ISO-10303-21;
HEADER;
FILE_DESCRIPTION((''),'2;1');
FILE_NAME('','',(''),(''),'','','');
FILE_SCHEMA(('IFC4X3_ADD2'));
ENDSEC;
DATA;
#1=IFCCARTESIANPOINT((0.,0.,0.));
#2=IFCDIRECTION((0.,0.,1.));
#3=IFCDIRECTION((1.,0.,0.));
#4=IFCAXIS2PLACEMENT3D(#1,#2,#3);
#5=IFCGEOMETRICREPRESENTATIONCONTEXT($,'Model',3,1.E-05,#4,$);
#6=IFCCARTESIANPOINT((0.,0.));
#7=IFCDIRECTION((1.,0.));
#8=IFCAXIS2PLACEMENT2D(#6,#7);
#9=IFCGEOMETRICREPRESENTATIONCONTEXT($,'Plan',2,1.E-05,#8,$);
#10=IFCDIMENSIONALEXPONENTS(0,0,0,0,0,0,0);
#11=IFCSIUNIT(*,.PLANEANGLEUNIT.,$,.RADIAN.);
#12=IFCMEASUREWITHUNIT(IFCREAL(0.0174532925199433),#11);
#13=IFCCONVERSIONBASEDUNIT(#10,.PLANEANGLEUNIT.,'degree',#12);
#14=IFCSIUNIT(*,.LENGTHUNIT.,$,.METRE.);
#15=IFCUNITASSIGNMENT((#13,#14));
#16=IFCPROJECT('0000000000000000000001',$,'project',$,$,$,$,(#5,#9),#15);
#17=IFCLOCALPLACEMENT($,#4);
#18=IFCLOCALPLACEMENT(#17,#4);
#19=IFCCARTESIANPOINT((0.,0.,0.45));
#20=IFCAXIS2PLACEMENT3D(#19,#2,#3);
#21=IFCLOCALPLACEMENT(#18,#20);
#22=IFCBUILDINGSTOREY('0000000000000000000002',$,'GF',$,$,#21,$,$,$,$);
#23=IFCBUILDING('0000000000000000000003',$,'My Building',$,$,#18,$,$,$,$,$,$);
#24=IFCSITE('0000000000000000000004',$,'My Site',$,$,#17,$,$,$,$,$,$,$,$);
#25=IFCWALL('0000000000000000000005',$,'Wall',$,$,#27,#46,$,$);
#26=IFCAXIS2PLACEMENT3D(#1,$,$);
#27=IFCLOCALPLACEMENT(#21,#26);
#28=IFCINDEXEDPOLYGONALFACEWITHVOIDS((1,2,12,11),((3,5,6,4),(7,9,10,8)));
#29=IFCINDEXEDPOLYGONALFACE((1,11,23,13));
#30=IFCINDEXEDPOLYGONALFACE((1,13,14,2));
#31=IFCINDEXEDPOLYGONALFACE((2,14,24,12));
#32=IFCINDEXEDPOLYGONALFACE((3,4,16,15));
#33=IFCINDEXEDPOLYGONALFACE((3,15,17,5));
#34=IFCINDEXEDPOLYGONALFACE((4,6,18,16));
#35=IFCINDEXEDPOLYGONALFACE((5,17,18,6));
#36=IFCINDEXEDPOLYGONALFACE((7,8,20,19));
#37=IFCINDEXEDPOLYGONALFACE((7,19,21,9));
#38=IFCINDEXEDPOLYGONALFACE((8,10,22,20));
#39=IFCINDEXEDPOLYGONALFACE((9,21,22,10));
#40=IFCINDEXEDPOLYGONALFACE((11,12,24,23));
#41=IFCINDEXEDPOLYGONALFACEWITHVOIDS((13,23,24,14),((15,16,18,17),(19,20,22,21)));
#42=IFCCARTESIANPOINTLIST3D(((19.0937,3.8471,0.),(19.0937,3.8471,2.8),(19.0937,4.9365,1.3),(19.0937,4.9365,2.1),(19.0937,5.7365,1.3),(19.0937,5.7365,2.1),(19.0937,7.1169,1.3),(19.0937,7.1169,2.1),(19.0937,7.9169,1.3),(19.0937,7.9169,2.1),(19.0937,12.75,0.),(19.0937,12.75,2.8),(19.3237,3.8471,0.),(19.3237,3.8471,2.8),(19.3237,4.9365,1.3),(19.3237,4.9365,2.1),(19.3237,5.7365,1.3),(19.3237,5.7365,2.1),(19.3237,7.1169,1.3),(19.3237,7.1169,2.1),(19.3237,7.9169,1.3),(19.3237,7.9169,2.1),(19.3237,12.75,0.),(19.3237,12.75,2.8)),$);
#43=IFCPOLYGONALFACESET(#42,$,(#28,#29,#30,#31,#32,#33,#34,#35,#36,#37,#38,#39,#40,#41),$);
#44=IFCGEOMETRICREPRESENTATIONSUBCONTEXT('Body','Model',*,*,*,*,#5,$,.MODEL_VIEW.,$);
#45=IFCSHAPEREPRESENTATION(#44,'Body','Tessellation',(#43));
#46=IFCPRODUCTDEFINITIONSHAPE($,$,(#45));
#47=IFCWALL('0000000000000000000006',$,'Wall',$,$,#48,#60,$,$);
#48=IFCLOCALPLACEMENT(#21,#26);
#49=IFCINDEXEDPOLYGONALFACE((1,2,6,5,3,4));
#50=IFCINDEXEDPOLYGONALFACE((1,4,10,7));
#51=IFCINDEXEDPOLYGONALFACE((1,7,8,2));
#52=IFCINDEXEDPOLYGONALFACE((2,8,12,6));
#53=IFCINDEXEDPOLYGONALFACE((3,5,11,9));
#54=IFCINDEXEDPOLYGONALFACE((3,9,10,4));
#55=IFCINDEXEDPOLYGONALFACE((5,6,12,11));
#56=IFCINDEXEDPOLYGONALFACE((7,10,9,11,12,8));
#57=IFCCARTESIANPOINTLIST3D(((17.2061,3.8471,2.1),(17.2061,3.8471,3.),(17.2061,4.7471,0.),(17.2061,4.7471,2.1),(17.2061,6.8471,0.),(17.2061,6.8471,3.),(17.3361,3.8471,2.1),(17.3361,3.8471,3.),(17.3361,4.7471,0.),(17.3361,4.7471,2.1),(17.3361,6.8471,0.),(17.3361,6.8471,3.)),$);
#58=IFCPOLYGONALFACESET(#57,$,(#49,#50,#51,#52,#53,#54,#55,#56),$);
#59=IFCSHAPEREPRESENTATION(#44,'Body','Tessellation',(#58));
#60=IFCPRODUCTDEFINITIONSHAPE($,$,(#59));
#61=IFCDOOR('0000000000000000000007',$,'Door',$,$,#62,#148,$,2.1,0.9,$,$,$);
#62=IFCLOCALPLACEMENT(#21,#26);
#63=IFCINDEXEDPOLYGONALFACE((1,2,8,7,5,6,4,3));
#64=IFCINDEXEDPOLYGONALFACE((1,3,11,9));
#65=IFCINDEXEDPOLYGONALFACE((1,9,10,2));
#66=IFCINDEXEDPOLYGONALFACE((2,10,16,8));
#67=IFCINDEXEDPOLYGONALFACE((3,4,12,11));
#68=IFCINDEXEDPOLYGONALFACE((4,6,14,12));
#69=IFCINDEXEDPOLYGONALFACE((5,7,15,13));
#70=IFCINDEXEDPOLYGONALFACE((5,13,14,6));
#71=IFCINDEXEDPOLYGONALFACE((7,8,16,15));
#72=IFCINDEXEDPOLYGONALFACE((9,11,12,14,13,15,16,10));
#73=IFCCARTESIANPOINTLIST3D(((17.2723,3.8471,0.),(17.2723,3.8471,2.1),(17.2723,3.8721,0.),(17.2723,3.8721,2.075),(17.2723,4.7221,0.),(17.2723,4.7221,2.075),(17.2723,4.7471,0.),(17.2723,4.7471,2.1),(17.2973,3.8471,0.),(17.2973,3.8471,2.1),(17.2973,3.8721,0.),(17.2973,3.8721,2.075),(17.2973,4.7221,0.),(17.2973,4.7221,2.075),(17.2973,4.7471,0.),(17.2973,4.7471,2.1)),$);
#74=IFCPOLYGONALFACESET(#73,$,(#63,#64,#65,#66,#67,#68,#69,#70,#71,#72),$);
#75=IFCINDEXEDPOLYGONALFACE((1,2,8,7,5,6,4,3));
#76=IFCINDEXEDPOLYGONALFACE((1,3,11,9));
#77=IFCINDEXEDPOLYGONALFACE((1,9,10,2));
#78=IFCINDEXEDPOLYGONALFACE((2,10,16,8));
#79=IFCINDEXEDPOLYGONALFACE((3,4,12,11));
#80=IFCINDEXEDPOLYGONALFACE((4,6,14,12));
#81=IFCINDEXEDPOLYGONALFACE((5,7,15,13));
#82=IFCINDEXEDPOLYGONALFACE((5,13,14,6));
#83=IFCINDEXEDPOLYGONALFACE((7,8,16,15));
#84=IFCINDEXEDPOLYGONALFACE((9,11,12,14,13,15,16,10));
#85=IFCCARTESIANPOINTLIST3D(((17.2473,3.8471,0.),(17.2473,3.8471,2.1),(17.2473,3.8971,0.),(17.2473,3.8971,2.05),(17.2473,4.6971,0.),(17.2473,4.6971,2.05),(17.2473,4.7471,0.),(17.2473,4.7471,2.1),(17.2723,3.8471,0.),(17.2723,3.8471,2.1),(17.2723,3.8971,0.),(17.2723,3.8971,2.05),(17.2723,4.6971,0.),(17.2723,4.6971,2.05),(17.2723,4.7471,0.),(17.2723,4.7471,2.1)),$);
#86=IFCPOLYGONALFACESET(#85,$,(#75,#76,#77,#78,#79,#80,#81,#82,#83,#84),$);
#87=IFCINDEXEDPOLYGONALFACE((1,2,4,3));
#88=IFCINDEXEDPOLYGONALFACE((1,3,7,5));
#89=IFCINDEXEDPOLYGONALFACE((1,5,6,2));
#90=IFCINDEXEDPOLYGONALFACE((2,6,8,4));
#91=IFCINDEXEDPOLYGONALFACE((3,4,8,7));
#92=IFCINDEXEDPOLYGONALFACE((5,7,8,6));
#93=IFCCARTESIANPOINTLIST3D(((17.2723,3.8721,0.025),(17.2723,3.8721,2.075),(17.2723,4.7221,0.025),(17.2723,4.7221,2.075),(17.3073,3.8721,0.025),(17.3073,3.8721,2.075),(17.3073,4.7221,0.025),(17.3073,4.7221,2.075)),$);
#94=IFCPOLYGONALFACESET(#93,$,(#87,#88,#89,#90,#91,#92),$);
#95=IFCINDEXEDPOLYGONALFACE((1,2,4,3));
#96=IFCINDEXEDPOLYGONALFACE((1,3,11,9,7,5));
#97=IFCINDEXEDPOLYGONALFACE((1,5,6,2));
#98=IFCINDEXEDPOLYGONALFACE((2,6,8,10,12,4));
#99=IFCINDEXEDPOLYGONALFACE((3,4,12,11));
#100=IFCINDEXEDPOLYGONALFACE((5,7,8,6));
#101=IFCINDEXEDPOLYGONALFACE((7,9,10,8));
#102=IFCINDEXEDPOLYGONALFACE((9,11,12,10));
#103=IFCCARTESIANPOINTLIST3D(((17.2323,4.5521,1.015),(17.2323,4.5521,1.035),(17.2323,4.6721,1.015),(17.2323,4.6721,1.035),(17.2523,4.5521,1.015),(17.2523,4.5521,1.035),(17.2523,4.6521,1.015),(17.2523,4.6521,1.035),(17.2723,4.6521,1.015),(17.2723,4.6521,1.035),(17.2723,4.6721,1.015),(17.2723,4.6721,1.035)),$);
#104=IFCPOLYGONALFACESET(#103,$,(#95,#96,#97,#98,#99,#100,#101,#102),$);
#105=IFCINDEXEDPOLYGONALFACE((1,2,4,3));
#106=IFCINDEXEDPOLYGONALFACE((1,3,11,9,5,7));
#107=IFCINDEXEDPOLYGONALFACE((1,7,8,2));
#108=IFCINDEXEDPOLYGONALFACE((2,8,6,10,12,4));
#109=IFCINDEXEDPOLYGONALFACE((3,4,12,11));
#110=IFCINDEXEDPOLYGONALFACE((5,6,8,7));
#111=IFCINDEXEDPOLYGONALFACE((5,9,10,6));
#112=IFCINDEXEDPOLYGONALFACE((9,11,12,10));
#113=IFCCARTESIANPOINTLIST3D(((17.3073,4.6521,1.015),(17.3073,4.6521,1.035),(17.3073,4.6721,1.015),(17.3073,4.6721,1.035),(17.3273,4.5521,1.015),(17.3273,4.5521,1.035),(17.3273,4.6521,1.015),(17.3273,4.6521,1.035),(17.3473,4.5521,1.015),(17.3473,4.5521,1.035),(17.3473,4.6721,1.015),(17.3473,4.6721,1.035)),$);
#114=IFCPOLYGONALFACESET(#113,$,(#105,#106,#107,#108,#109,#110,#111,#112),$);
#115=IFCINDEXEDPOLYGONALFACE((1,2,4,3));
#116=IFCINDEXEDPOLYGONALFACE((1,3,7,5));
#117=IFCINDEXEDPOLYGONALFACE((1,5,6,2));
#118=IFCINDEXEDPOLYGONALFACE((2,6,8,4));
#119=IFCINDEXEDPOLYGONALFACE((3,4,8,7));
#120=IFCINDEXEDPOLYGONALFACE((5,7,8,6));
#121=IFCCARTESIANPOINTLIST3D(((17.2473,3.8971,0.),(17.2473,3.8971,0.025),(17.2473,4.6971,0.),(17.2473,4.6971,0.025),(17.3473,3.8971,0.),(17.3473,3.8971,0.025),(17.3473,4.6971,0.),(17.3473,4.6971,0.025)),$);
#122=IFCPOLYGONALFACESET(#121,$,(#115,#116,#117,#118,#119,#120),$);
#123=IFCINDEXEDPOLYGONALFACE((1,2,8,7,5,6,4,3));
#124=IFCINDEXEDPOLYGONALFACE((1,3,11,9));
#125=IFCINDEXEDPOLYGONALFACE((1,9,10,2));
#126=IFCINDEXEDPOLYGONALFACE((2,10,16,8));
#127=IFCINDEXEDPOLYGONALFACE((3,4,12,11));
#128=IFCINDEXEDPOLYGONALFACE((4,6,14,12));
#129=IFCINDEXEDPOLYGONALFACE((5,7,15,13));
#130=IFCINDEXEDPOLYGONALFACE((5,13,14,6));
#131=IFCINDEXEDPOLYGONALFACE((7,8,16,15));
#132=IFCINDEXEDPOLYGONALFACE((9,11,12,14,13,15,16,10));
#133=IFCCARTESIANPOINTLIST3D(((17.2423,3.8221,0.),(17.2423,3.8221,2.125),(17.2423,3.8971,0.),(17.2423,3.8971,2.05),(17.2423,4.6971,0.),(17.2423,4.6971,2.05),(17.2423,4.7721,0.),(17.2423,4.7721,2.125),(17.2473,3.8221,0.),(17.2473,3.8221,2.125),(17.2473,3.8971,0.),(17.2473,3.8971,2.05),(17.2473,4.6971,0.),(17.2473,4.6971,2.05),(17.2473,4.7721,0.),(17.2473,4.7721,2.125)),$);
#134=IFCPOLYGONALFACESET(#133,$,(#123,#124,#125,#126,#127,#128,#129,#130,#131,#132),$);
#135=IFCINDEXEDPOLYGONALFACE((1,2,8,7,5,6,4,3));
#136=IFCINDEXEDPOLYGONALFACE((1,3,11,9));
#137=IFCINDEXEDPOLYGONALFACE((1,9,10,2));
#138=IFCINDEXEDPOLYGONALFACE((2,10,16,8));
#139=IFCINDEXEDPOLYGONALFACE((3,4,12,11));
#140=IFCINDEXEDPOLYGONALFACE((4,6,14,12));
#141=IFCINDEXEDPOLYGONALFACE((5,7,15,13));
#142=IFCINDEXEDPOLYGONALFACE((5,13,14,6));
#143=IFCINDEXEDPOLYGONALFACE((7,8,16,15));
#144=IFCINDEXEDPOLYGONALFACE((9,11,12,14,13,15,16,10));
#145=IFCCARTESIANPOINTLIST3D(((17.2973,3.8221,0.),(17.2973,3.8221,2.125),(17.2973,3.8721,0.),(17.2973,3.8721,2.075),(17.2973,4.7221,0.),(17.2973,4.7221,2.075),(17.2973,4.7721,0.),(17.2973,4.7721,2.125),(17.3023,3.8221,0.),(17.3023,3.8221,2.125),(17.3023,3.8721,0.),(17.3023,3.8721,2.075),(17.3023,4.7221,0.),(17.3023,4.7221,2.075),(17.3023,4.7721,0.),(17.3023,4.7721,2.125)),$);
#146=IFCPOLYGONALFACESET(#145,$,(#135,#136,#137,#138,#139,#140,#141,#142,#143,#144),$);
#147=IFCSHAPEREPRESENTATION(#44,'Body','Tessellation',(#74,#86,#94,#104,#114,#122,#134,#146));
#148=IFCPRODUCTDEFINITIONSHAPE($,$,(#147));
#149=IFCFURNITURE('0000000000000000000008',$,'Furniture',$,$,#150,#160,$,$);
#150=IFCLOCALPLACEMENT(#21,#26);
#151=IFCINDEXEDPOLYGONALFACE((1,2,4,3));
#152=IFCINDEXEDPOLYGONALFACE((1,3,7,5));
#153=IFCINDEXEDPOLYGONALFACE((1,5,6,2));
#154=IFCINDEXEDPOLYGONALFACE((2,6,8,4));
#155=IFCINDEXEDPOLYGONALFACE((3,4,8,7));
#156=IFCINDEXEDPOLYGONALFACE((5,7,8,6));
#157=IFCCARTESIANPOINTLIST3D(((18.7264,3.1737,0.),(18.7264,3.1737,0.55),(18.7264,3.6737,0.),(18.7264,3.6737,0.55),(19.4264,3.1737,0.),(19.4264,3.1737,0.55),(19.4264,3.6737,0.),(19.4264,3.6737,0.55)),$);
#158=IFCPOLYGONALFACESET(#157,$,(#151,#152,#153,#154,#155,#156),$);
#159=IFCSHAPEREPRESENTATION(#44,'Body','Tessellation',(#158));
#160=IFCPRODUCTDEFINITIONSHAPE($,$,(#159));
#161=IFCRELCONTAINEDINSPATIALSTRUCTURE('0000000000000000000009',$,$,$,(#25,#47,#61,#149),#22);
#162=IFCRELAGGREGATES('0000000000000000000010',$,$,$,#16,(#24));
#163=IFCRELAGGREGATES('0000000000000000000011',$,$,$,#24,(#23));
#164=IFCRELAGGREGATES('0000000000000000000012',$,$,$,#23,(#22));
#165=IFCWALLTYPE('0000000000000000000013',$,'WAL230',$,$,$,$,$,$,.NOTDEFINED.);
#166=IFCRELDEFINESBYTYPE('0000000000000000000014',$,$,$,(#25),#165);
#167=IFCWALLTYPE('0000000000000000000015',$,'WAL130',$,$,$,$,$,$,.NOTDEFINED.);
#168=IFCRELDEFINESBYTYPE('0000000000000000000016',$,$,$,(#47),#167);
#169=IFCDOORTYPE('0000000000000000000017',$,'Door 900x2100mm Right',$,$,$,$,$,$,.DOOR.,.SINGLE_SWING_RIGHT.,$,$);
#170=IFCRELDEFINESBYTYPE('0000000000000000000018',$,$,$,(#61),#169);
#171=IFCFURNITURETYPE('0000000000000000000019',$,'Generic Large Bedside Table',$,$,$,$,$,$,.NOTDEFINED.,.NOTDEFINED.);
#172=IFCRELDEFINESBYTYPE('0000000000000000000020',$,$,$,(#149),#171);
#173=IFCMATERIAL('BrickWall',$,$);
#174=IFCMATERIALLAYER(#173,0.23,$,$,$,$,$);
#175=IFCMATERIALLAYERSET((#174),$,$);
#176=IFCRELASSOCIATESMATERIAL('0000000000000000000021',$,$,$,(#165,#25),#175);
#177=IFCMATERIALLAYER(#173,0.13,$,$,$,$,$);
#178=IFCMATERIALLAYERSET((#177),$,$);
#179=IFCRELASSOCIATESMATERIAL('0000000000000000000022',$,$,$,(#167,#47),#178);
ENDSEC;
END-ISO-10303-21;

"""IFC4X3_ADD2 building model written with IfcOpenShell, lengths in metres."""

from ifc_helpers import new_model, entity, si_unit, converted_unit, frame, origin_with_axes, origin_2d_with_axis, place, context, subcontext, project, spatial, line, indexed_curve, outline, extrude, shape, source, transform, mapped, material, layer, layer_set, layer_usage, type_object, type_shapes, element, fill, save


model = new_model("IFC4X3_ADD2")

# Units and contexts
model_context = context("Model", 3, precision=1e-05, world=origin_with_axes())
plan_context = context("Plan", 2, precision=1e-05, world=origin_2d_with_axis())
body_context_1 = subcontext(model_context, "Body", "Model", "MODEL_VIEW")
body_context_2 = subcontext(plan_context, "Body", "Plan", "PLAN_VIEW")
ifc_project = project(units=[converted_unit("PLANEANGLEUNIT", "degree", entity("IfcReal", 0.0174532925199433), si_unit("PLANEANGLEUNIT", "RADIAN"), dimensions=[0, 0, 0, 0, 0, 0, 0]), si_unit("LENGTHUNIT", "METRE")], contexts=[model_context, plan_context])

# Site, building, storey
site_placement = place(None, origin_with_axes())
site = spatial("IfcSite", under=ifc_project, at=site_placement, Name="My Site")
building_placement = place(site_placement, origin_with_axes())
building = spatial("IfcBuilding", under=site, at=building_placement, Name="My Building")
storey_placement = place(building_placement, frame((0.0, 0.0, 0.45), z_axis=(0.0, 0.0, 1.0), x_axis=(1.0, 0.0, 0.0)))
storey = spatial("IfcBuildingStorey", under=building, at=storey_placement, Name="GF")

# Shared definitions
ifc_material = material(Name="BrickWall")
ifc_layer_1 = layer(ifc_material, 0.23)
ifc_layer_set_1 = layer_set([ifc_layer_1])
wall_type_1 = type_object("IfcWallType", Name="WAL230", PredefinedType="NOTDEFINED", material=ifc_layer_set_1)

# Wall, openings
ifc_layer_usage_1 = layer_usage(ifc_layer_set_1, "AXIS2", "POSITIVE", 0.0)
wall_1_placement = place(storey_placement, frame((19.3237, 3.8471, 0.0), z_axis=(0.0, 0.0, 1.0), x_axis=(0.0, 1.0, 0.0)))
wall_1 = element("IfcWall", 1, at=wall_1_placement, inside=storey, type_object=wall_type_1, material=ifc_layer_usage_1, Name="Wall", context=body_context_1, shape_type="SweptSolid", body=[
    extrude(outline(indexed_curve([(0.0, 0.0), (0.0, 0.23), (8.9029, 0.23), (8.9029, 0.0), (0.0, 0.0)], self_intersect=False)), origin_with_axes(), (0.0, 0.0, 1.0), 2.8),
])
shared_shape_1 = source(origin_with_axes(), body_context_1, "Body", "SweptSolid", [
    extrude(outline(indexed_curve([(0.0, 0.0), (0.8, 0.0), (0.8, 0.8), (0.0, 0.8)], segments=[line(1, 2, 3, 4, 1)])), frame((-0.4, -0.6, 0.0), z_axis=(0.0, -1.0, 0.0), x_axis=(1.0, 0.0, 0.0)), (0.0, 0.0, -1.0), 1.2),
])
opening_1_placement = place(wall_1_placement, frame((1.4894, 0.0, 1.3), z_axis=(0.0, 0.0, 1.0), x_axis=(1.0, 0.0, 0.0)))
element("IfcOpeningElement", 2, at=opening_1_placement, cuts=wall_1, PredefinedType="OPENING", context=body_context_1, shape_type="MappedRepresentation", body=[
    mapped(shared_shape_1, transform((0.0, 0.0, 0.0), x_axis=(1.0, 0.0, 0.0), y_axis=(0.0, 1.0, 0.0), z_axis=(0.0, 0.0, 1.0), scale=1.0)),
])
opening_2_placement = place(wall_1_placement, frame((3.6698, 0.0, 1.3), z_axis=(0.0, 0.0, 1.0), x_axis=(1.0, 0.0, 0.0)))
element("IfcOpeningElement", 3, at=opening_2_placement, cuts=wall_1, PredefinedType="OPENING", context=body_context_1, shape_type="MappedRepresentation", body=[
    mapped(shared_shape_1, transform((0.0, 0.0, 0.0), x_axis=(1.0, 0.0, 0.0), y_axis=(0.0, 1.0, 0.0), z_axis=(0.0, 0.0, 1.0), scale=1.0)),
])

# Wall, opening, door
ifc_layer_2 = layer(ifc_material, 0.13)
ifc_layer_set_2 = layer_set([ifc_layer_2])
ifc_layer_usage_2 = layer_usage(ifc_layer_set_2, "AXIS2", "POSITIVE", 0.0)
wall_type_2 = type_object("IfcWallType", Name="WAL130", PredefinedType="NOTDEFINED", material=ifc_layer_set_2)
wall_2_placement = place(storey_placement, frame((17.3361, 3.8471, 0.0), z_axis=(0.0, 0.0, 1.0), x_axis=(0.0, 1.0, 0.0)))
wall_2 = element("IfcWall", 4, at=wall_2_placement, inside=storey, type_object=wall_type_2, material=ifc_layer_usage_2, Name="Wall", context=body_context_1, shape_type="SweptSolid", body=[
    extrude(outline(indexed_curve([(0.0, 0.0), (0.0, 0.13), (3.0, 0.13), (3.0, 0.0), (0.0, 0.0)], self_intersect=False)), origin_with_axes(), (0.0, 0.0, 1.0), 3.0),
])
shared_shape_2 = source(origin_with_axes(), body_context_1, "Body", "SweptSolid", [
    extrude(outline(indexed_curve([(0.0, 0.0), (0.9, 0.0), (0.9, 2.1), (0.0, 2.1)], segments=[line(1, 2, 3, 4, 1)])), frame((0.0, -0.6, 0.0), z_axis=(0.0, -1.0, 0.0), x_axis=(1.0, 0.0, 0.0)), (0.0, 0.0, -1.0), 1.2),
])
opening_3_placement = place(wall_2_placement, frame((0.9, 0.0887, 0.0), z_axis=(0.0, 0.0, 1.0), x_axis=(-1.0, 0.0, 0.0)))
opening_3 = element("IfcOpeningElement", 5, at=opening_3_placement, cuts=wall_2, PredefinedType="OPENING", context=body_context_1, shape_type="MappedRepresentation", body=[
    mapped(shared_shape_2, transform((0.0, 0.0, 0.0), x_axis=(1.0, 0.0, 0.0), y_axis=(0.0, 1.0, 0.0), z_axis=(0.0, 0.0, 1.0), scale=1.0)),
])
door_type = type_object("IfcDoorType", Name="Door 900x2100mm Right", OperationType="SINGLE_SWING_RIGHT", PredefinedType="DOOR")
shared_shape_3 = source(origin_with_axes(), body_context_1, "Body", "SweptSolid", [
    extrude(outline(indexed_curve([(0.0, 0.0), (0.0, 2.1), (0.9, 2.1), (0.9, 0.0), (0.875, 0.0), (0.875, 2.075), (0.025, 2.075), (0.025, 0.0)], segments=[line(1, 2, 3, 4, 5, 6, 7, 8, 1)])), frame((0.0, 0.025, 0.0), z_axis=(0.0, -1.0, 0.0), x_axis=(1.0, 0.0, 0.0)), (0.0, 0.0, -1.0), 0.025),
    extrude(outline(indexed_curve([(0.0, 0.0), (0.0, 2.1), (0.9, 2.1), (0.9, 0.0), (0.85, 0.0), (0.85, 2.05), (0.05, 2.05), (0.05, 0.0)], segments=[line(1, 2, 3, 4, 5, 6, 7, 8, 1)])), frame((0.0, 0.0, 0.0), z_axis=(0.0, -1.0, 0.0), x_axis=(1.0, 0.0, 0.0)), (0.0, 0.0, -1.0), 0.025),
    extrude(outline(indexed_curve([(0.0, 0.0), (0.85, 0.0), (0.85, 0.035), (0.0, 0.035)], segments=[line(1, 2, 3, 4, 1)])), frame((0.025, 0.025, 0.025), z_axis=(0.0, 0.0, 1.0), x_axis=(1.0, 0.0, 0.0)), (0.0, 0.0, 1.0), 2.05),
    extrude(outline(indexed_curve([(0.0, 0.0), (0.0, -0.04), (0.12, -0.04), (0.12, -0.02), (0.02, -0.02), (0.02, 0.0)], segments=[line(1, 2, 3, 4, 5, 6, 1)])), frame((0.075, 0.025, 1.015), z_axis=(0.0, 0.0, 1.0), x_axis=(1.0, 0.0, 0.0)), (0.0, 0.0, 1.0), 0.02),
    extrude(outline(indexed_curve([(0.0, 0.0), (0.0, 0.04), (0.12, 0.04), (0.12, 0.02), (0.02, 0.02), (0.02, 0.0)], segments=[line(1, 2, 3, 4, 5, 6, 1)])), frame((0.075, 0.06, 1.015), z_axis=(0.0, 0.0, 1.0), x_axis=(1.0, 0.0, 0.0)), (0.0, 0.0, 1.0), 0.02),
    extrude(outline(indexed_curve([(0.0, 0.0), (0.8, 0.0), (0.8, 0.1), (0.0, 0.1)], segments=[line(1, 2, 3, 4, 1)])), frame((0.05, 0.0, 0.0), z_axis=(0.0, 0.0, 1.0), x_axis=(1.0, 0.0, 0.0)), (0.0, 0.0, 1.0), 0.025),
    extrude(outline(indexed_curve([(0.0, 0.0), (0.0, 2.125), (0.95, 2.125), (0.95, 0.0), (0.875, 0.0), (0.875, 2.05), (0.075, 2.05), (0.075, 0.0)], segments=[line(1, 2, 3, 4, 5, 6, 7, 8, 1)])), frame((-0.025, -0.005, 0.0), z_axis=(0.0, -1.0, 0.0), x_axis=(1.0, 0.0, 0.0)), (0.0, 0.0, -1.0), 0.005),
    extrude(outline(indexed_curve([(0.0, 0.0), (0.0, 2.125), (0.95, 2.125), (0.95, 0.0), (0.9, 0.0), (0.9, 2.075), (0.05, 2.075), (0.05, 0.0)], segments=[line(1, 2, 3, 4, 5, 6, 7, 8, 1)])), frame((-0.025, 0.05, 0.0), z_axis=(0.0, -1.0, 0.0), x_axis=(1.0, 0.0, 0.0)), (0.0, 0.0, -1.0), 0.005),
])
shared_shape_4 = source(origin_with_axes(), body_context_2, "Body", "Curve2D", [
    entity("IfcIndexedPolyCurve", entity("IfcCartesianPointList2D", [[0.0, 0.0], [0.0, 0.05], [0.025, 0.05], [0.025, 0.025], [0.05, 0.025], [0.05, 0.0]]), [entity("IfcLineIndex", [1, 2, 3, 4, 5, 6, 1])]),
    entity("IfcIndexedPolyCurve", entity("IfcCartesianPointList2D", [[0.9, 0.0], [0.9, 0.05], [0.875, 0.05], [0.875, 0.025], [0.85, 0.025], [0.85, 0.0]]), [entity("IfcLineIndex", [1, 2, 3, 4, 5, 6, 1])]),
    entity("IfcTrimmedCurve", entity("IfcEllipse", entity("IfcAxis2Placement2D", entity("IfcCartesianPoint", [0.84, 0.05]), entity("IfcDirection", [1.0, 0.0])), 0.815, 0.85), [entity("IfcCartesianPoint", [0.84, 0.9])], [entity("IfcCartesianPoint", [0.025, 0.05])], True, "CARTESIAN"),
    entity("IfcIndexedPolyCurve", entity("IfcCartesianPointList2D", [[0.875, 0.05], [0.84, 0.05], [0.84, 0.9], [0.875, 0.9]]), [entity("IfcLineIndex", [1, 2, 3, 4, 1])]),
])
type_shapes(door_type, [shared_shape_3, shared_shape_4])
door_placement = place(opening_3_placement, frame((0.0, 0.0, 0.0), z_axis=(0.0, 0.0, 1.0), x_axis=(1.0, 0.0, 0.0)))
door = element("IfcDoor", 6, at=door_placement, inside=storey, type_object=door_type, Name="Door", OverallHeight=2.1, OverallWidth=0.9, shapes=[
    shape(body_context_1, "Body", "MappedRepresentation", [mapped(shared_shape_3, transform((0.0, 0.0, 0.0), x_axis=(1.0, 0.0, 0.0), y_axis=(0.0, 1.0, 0.0), z_axis=(0.0, 0.0, 1.0), scale=1.0))]),
    shape(body_context_2, "Body", "MappedRepresentation", [mapped(shared_shape_4, transform((0.0, 0.0, 0.0), x_axis=(1.0, 0.0, 0.0), y_axis=(0.0, 1.0, 0.0), z_axis=(0.0, 0.0, 1.0), scale=1.0))]),
])
fill(opening_3, door)

# Furniture
furniture_type_1 = type_object("IfcFurnitureType", Name="Generic Large Bedside Table", AssemblyPlace="NOTDEFINED", PredefinedType="NOTDEFINED")
shared_shape_5 = source(origin_with_axes(), body_context_1, "Body", "SweptSolid", [
    extrude(outline(indexed_curve([(0.0, 0.0), (0.7, 0.0), (0.7, 0.5), (0.0, 0.5)], segments=[line(1, 2, 3, 4, 1)])), frame((-0.35, -0.25, 0.0), z_axis=(0.0, 0.0, 1.0), x_axis=(1.0, 0.0, 0.0)), (0.0, 0.0, 1.0), 0.55),
])
shared_shape_6 = source(origin_with_axes(), body_context_2, "Body", "Curve2D", [
    entity("IfcIndexedPolyCurve", entity("IfcCartesianPointList2D", [[-0.35, -0.25], [0.35, -0.25], [0.35, 0.25], [-0.35, 0.25]]), [entity("IfcLineIndex", [1, 2, 3, 4, 1])]),
])
type_shapes(furniture_type_1, [shared_shape_5, shared_shape_6])
for number, where, z_axis, x_axis, name in (
    (7, (19.0764, 3.4237, 0.0), (0.0, 0.0, 1.0), (1.0, 0.0, 0.0), "Furniture"),
):
    element("IfcFurniture", number, at=place(storey_placement, frame(where, z_axis=z_axis, x_axis=x_axis)), inside=storey, type_object=furniture_type_1, Name=name, shapes=[
        shape(body_context_1, "Body", "MappedRepresentation", [mapped(shared_shape_5, transform((0.0, 0.0, 0.0), x_axis=(1.0, 0.0, 0.0), y_axis=(0.0, 1.0, 0.0), z_axis=(0.0, 0.0, 1.0), scale=1.0))]),
        shape(body_context_2, "Body", "MappedRepresentation", [mapped(shared_shape_6, transform((0.0, 0.0, 0.0), x_axis=(1.0, 0.0, 0.0), y_axis=(0.0, 1.0, 0.0), z_axis=(0.0, 0.0, 1.0), scale=1.0))]),
    ])

save(model, "model.ifc")
